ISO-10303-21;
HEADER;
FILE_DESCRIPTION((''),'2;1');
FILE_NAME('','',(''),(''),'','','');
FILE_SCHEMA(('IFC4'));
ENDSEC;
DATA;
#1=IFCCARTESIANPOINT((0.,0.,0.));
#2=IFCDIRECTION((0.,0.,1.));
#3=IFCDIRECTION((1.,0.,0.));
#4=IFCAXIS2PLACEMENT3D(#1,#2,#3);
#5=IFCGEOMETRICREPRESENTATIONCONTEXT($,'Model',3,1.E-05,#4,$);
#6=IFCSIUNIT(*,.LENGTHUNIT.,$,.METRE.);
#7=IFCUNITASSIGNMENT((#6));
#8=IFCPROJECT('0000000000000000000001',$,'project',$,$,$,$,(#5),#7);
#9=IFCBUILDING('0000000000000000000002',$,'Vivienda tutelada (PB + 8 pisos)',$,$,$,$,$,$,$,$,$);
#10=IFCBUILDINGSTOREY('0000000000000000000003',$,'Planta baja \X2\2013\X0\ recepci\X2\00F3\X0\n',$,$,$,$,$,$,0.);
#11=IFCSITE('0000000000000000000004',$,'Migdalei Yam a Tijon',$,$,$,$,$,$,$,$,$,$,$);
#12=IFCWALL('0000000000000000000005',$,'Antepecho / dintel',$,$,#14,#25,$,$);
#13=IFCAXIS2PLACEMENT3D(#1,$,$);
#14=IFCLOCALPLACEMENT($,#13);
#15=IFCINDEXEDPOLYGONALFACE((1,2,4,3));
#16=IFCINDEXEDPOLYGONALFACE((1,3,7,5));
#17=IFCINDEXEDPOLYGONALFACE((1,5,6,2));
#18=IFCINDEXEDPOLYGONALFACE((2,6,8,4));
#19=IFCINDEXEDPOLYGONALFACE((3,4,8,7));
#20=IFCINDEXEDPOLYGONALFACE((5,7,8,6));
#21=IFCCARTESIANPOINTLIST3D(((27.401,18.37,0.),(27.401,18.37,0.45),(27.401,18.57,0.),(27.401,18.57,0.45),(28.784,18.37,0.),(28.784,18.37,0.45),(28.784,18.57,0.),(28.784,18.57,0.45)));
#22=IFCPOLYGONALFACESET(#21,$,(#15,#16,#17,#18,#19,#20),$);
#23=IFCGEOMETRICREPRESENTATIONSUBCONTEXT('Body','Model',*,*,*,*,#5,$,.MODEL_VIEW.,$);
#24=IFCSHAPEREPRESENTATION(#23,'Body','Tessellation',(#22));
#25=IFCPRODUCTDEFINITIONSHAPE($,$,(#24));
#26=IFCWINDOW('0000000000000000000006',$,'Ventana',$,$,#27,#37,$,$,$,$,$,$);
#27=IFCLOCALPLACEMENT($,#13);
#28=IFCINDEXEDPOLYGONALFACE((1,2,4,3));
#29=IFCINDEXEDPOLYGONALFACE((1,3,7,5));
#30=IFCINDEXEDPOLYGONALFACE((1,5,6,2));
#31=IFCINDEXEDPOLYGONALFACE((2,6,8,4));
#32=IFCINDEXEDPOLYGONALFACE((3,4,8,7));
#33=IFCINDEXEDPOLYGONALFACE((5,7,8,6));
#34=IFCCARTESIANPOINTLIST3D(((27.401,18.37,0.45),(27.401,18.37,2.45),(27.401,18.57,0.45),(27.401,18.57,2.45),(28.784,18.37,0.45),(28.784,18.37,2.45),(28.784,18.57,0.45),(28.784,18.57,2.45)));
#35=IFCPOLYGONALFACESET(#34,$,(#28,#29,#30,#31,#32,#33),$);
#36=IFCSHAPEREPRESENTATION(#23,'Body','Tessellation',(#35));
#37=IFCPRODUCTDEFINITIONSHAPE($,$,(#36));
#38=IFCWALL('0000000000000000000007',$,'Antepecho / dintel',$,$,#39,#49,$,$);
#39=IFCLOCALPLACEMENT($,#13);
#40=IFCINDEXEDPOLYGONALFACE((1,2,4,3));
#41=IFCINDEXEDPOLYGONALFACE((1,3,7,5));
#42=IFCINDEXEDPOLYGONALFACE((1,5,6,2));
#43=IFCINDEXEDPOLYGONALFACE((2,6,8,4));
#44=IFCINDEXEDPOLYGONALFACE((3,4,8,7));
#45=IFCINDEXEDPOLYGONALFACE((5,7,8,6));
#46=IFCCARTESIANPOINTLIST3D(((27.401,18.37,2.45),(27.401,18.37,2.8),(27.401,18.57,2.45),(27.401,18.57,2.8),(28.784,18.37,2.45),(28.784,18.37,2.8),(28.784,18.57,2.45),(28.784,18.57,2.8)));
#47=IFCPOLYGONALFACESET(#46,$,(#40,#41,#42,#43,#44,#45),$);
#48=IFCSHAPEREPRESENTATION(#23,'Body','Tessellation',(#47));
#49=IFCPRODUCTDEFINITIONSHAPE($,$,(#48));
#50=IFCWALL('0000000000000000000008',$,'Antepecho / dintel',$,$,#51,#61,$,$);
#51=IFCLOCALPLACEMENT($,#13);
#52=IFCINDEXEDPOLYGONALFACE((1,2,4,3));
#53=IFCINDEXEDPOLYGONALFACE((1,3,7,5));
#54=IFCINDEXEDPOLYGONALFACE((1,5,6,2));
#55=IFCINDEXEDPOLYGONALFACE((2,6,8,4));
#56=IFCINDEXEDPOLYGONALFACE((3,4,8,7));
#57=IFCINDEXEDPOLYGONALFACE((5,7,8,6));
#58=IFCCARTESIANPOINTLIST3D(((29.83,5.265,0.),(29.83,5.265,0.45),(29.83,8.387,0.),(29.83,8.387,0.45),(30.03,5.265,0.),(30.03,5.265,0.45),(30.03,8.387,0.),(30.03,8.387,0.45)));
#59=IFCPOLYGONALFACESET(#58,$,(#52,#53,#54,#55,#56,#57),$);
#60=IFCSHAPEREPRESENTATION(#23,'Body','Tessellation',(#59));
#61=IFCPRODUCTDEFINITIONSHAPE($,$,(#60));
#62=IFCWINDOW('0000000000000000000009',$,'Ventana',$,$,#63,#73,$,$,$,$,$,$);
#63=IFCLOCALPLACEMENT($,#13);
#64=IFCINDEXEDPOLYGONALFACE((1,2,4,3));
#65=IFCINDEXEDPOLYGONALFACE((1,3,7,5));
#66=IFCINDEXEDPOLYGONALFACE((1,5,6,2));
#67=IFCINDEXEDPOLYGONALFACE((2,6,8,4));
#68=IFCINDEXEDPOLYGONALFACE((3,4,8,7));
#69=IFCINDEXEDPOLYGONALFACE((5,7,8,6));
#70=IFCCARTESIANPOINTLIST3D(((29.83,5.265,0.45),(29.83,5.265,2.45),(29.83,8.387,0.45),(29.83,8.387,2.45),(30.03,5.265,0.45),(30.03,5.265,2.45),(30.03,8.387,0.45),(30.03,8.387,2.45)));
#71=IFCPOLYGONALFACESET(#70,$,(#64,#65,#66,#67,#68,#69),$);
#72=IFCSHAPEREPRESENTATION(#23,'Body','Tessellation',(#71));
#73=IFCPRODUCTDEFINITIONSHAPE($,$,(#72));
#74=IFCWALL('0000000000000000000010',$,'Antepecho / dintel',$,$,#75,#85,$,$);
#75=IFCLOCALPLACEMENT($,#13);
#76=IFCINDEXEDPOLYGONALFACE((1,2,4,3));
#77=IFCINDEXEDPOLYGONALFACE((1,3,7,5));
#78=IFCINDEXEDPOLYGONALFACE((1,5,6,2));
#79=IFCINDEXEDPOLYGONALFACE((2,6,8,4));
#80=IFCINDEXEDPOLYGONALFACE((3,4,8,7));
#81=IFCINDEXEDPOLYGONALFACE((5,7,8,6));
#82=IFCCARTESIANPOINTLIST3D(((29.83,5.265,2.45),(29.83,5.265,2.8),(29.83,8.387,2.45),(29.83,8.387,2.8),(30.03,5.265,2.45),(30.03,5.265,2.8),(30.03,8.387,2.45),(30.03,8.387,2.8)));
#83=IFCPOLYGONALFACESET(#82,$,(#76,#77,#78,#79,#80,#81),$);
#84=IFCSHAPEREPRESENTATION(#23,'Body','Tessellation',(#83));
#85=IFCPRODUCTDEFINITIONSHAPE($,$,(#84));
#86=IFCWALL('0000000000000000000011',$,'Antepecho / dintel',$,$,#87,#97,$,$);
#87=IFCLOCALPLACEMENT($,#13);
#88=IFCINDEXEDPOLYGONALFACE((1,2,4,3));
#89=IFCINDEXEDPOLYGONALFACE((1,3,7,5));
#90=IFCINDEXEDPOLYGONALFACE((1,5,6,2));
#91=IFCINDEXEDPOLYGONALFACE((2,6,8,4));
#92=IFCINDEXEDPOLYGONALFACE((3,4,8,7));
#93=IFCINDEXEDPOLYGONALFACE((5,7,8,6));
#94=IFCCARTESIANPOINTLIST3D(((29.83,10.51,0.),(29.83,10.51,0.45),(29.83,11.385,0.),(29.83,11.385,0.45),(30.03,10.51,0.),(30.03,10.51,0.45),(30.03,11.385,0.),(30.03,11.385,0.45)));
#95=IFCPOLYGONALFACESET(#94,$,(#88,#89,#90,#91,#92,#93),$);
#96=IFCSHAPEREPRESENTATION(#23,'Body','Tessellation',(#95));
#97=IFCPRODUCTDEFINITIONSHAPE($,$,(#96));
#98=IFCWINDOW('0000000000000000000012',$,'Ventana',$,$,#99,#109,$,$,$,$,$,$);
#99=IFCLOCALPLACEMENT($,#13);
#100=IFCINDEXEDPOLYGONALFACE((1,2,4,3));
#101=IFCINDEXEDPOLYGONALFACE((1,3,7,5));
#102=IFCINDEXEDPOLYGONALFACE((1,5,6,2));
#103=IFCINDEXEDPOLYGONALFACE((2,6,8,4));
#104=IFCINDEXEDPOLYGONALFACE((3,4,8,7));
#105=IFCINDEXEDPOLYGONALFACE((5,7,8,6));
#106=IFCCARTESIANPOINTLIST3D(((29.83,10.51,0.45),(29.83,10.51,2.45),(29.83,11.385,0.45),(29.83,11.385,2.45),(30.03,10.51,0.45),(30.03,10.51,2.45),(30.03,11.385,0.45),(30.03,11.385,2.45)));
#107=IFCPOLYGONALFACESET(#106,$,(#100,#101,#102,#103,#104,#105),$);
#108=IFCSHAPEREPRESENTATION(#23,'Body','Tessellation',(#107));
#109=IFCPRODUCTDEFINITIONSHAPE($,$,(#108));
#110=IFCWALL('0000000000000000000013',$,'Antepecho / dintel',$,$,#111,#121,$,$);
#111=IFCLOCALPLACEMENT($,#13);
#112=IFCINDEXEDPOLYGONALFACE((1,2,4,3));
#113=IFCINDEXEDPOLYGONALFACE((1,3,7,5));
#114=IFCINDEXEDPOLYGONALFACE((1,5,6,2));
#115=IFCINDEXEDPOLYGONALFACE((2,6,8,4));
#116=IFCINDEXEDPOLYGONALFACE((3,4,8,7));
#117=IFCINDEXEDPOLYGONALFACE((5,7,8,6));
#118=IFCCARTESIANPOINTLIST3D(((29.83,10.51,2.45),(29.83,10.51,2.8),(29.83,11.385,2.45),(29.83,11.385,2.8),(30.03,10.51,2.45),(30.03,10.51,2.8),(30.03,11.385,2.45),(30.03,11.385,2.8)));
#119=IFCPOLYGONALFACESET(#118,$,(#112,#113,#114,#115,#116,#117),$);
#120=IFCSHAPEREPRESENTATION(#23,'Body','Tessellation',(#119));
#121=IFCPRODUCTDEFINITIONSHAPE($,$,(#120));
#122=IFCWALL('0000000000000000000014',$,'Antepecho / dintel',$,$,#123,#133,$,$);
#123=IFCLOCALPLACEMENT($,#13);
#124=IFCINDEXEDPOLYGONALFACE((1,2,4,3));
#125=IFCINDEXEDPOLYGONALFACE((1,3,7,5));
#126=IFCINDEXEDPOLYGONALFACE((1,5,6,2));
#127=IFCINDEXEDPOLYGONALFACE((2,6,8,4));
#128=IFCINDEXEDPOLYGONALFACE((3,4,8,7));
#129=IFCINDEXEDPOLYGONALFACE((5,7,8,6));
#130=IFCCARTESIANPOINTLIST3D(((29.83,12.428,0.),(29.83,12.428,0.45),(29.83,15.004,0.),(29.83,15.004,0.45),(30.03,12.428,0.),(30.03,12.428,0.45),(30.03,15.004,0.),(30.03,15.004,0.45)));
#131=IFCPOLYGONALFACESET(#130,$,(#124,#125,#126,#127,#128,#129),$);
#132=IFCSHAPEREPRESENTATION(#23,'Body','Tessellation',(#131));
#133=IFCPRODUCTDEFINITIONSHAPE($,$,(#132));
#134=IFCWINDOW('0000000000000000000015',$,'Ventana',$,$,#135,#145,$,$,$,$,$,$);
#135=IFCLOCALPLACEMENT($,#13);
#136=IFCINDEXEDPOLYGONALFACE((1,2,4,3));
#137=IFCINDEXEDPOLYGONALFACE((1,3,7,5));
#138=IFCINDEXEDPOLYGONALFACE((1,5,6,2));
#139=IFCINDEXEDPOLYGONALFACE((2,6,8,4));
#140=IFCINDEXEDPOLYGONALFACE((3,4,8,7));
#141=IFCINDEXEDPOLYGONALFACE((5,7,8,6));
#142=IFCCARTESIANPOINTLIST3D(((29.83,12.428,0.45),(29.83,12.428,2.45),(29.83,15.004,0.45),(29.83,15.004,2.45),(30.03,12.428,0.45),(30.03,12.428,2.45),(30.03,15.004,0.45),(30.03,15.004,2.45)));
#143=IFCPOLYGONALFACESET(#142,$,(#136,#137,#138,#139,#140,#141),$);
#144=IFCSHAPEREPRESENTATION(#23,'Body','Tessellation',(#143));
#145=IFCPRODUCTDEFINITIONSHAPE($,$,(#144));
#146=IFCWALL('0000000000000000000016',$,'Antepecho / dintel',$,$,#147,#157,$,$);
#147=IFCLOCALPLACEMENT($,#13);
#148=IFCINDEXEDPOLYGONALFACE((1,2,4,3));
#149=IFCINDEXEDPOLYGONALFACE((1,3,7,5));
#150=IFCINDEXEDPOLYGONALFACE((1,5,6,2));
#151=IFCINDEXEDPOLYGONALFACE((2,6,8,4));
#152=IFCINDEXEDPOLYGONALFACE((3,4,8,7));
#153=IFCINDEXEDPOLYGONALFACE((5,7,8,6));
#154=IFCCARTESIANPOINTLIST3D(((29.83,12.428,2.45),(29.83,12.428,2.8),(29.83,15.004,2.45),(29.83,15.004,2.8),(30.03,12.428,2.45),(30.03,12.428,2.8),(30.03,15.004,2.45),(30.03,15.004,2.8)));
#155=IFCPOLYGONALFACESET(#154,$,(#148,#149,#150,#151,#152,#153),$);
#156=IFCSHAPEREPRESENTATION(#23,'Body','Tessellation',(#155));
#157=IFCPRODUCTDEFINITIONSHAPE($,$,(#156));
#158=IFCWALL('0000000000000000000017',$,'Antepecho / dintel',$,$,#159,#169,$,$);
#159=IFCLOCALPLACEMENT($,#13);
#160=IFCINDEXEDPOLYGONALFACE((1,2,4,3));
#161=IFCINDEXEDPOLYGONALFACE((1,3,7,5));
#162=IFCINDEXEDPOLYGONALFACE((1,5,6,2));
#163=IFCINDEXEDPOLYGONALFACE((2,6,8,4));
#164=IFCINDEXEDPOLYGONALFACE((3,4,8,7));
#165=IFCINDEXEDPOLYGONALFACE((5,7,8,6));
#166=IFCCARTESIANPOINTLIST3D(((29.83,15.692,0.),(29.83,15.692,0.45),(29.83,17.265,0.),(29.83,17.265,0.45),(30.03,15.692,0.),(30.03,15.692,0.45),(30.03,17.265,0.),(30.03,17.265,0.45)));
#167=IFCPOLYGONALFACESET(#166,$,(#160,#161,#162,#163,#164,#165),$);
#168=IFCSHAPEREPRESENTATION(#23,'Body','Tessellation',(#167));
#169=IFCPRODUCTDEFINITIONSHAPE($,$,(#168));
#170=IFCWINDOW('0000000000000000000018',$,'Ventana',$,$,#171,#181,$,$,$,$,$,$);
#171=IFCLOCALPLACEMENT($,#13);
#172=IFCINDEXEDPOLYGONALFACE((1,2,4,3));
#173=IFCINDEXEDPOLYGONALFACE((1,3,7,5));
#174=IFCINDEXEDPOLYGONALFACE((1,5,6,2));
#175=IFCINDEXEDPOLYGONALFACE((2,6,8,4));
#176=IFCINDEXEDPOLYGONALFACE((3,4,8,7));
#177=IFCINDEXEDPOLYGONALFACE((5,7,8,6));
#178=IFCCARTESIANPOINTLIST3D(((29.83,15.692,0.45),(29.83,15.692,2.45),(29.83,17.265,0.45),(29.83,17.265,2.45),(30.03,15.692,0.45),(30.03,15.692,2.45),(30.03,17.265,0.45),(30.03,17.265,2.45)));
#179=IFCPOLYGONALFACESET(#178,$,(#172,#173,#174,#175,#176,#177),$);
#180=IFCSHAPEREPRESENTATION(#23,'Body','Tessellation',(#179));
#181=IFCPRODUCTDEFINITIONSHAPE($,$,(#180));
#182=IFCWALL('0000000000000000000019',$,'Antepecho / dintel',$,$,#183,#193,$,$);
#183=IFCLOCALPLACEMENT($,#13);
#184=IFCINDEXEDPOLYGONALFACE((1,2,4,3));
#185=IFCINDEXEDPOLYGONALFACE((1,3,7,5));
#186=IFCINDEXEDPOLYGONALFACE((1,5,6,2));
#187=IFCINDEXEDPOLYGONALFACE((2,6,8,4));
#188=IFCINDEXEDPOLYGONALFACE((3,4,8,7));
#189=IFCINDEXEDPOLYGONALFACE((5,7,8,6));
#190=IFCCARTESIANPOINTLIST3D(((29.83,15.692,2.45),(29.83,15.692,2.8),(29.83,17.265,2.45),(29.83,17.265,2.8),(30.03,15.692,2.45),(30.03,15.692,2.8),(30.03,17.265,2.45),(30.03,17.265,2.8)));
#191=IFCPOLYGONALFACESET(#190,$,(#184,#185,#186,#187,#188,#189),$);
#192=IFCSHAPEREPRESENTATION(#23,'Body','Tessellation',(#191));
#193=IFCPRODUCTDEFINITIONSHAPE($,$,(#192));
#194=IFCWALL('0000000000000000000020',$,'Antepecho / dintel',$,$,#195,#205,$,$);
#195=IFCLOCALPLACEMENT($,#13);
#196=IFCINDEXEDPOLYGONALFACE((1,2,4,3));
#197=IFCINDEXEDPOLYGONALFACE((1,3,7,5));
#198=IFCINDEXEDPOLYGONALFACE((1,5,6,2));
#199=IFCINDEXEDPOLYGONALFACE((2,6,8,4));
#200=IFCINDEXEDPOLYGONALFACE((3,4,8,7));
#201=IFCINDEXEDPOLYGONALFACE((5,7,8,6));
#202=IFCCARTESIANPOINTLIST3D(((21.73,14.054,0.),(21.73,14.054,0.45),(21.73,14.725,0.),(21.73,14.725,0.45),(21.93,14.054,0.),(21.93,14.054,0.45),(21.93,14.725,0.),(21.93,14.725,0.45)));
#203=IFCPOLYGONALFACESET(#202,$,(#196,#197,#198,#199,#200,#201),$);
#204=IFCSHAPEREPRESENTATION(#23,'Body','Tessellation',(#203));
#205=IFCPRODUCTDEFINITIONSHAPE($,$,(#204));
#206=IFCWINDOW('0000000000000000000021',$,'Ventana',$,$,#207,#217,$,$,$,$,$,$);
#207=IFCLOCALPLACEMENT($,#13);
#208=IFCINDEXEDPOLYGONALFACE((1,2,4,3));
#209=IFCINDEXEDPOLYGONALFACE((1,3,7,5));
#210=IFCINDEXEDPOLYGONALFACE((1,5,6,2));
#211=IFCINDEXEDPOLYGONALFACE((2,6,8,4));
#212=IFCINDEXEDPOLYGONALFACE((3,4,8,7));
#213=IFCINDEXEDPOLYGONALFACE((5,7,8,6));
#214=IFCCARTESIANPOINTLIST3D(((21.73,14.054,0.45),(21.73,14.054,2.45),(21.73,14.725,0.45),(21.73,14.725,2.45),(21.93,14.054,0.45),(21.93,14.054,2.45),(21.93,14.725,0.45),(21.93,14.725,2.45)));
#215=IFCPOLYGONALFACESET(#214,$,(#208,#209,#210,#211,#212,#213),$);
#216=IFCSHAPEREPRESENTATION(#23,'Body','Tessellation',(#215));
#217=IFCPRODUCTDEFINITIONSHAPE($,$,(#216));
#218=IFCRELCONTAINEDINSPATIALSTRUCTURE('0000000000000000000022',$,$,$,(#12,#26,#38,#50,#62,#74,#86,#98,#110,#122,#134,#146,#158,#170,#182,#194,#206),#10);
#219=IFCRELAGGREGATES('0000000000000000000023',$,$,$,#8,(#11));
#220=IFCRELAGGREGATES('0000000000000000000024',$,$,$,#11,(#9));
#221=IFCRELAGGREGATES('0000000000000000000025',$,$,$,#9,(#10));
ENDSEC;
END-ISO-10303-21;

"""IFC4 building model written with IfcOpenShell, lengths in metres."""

from ifc_helpers import new_model, si_unit, frame, origin_with_axes, context, subcontext, project, spatial, line, indexed_curve, outline, extrude, element, save


model = new_model("IFC4")

# Units and contexts
model_context = context("Model", 3, precision=1e-05, world=origin_with_axes())
body_context = subcontext(model_context, "Body", "Model", "MODEL_VIEW")
ifc_project = project(units=[si_unit("LENGTHUNIT", "METRE")], contexts=[model_context])

# Site, building, storey
site = spatial("IfcSite", under=ifc_project, Name="Migdalei Yam a Tijon")
building = spatial("IfcBuilding", under=site, Name="Vivienda tutelada (PB + 8 pisos)")
storey = spatial("IfcBuildingStorey", under=building, Name="Planta baja – recepción", Elevation=0.0)

# Wall
element("IfcWall", 1, inside=storey, Name="Antepecho / dintel", context=body_context, shape_type="SweptSolid", body=[
    extrude(outline(indexed_curve([(0.0, 0.0), (1.383, 0.0), (1.383, 0.2), (0.0, 0.2)], segments=[line(1, 2, 3, 4, 1)])), frame((27.401, 18.37, 0.0), z_axis=(0.0, 0.0, 1.0), x_axis=(1.0, 0.0, 0.0)), (0.0, 0.0, 1.0), 0.45),
])

# Window
element("IfcWindow", 2, inside=storey, Name="Ventana", context=body_context, shape_type="SweptSolid", body=[
    extrude(outline(indexed_curve([(0.0, 0.0), (1.383, 0.0), (1.383, 0.2), (0.0, 0.2)], segments=[line(1, 2, 3, 4, 1)])), frame((27.401, 18.37, 0.45), z_axis=(0.0, 0.0, 1.0), x_axis=(1.0, 0.0, 0.0)), (0.0, 0.0, 1.0), 2.0),
])

# Walls
element("IfcWall", 3, inside=storey, Name="Antepecho / dintel", context=body_context, shape_type="SweptSolid", body=[
    extrude(outline(indexed_curve([(0.0, 0.0), (1.383, 0.0), (1.383, 0.2), (0.0, 0.2)], segments=[line(1, 2, 3, 4, 1)])), frame((27.401, 18.37, 2.45), z_axis=(0.0, 0.0, 1.0), x_axis=(1.0, 0.0, 0.0)), (0.0, 0.0, 1.0), 0.35),
])
element("IfcWall", 4, inside=storey, Name="Antepecho / dintel", context=body_context, shape_type="SweptSolid", body=[
    extrude(outline(indexed_curve([(0.0, 0.0), (0.2, 0.0), (0.2, 3.122), (0.0, 3.122)], segments=[line(1, 2, 3, 4, 1)])), frame((29.83, 5.265, 0.0), z_axis=(0.0, 0.0, 1.0), x_axis=(1.0, 0.0, 0.0)), (0.0, 0.0, 1.0), 0.45),
])

# Window
element("IfcWindow", 5, inside=storey, Name="Ventana", context=body_context, shape_type="SweptSolid", body=[
    extrude(outline(indexed_curve([(0.0, 0.0), (0.2, 0.0), (0.2, 3.122), (0.0, 3.122)], segments=[line(1, 2, 3, 4, 1)])), frame((29.83, 5.265, 0.45), z_axis=(0.0, 0.0, 1.0), x_axis=(1.0, 0.0, 0.0)), (0.0, 0.0, 1.0), 2.0),
])

# Walls
element("IfcWall", 6, inside=storey, Name="Antepecho / dintel", context=body_context, shape_type="SweptSolid", body=[
    extrude(outline(indexed_curve([(0.0, 0.0), (0.2, 0.0), (0.2, 3.122), (0.0, 3.122)], segments=[line(1, 2, 3, 4, 1)])), frame((29.83, 5.265, 2.45), z_axis=(0.0, 0.0, 1.0), x_axis=(1.0, 0.0, 0.0)), (0.0, 0.0, 1.0), 0.35),
])
element("IfcWall", 7, inside=storey, Name="Antepecho / dintel", context=body_context, shape_type="SweptSolid", body=[
    extrude(outline(indexed_curve([(0.0, 0.0), (0.2, 0.0), (0.2, 0.875), (0.0, 0.875)], segments=[line(1, 2, 3, 4, 1)])), frame((29.83, 10.51, 0.0), z_axis=(0.0, 0.0, 1.0), x_axis=(1.0, 0.0, 0.0)), (0.0, 0.0, 1.0), 0.45),
])

# Window
element("IfcWindow", 8, inside=storey, Name="Ventana", context=body_context, shape_type="SweptSolid", body=[
    extrude(outline(indexed_curve([(0.0, 0.0), (0.2, 0.0), (0.2, 0.875), (0.0, 0.875)], segments=[line(1, 2, 3, 4, 1)])), frame((29.83, 10.51, 0.45), z_axis=(0.0, 0.0, 1.0), x_axis=(1.0, 0.0, 0.0)), (0.0, 0.0, 1.0), 2.0),
])

# Walls
element("IfcWall", 9, inside=storey, Name="Antepecho / dintel", context=body_context, shape_type="SweptSolid", body=[
    extrude(outline(indexed_curve([(0.0, 0.0), (0.2, 0.0), (0.2, 0.875), (0.0, 0.875)], segments=[line(1, 2, 3, 4, 1)])), frame((29.83, 10.51, 2.45), z_axis=(0.0, 0.0, 1.0), x_axis=(1.0, 0.0, 0.0)), (0.0, 0.0, 1.0), 0.35),
])
element("IfcWall", 10, inside=storey, Name="Antepecho / dintel", context=body_context, shape_type="SweptSolid", body=[
    extrude(outline(indexed_curve([(0.0, 0.0), (0.2, 0.0), (0.2, 2.576), (0.0, 2.576)], segments=[line(1, 2, 3, 4, 1)])), frame((29.83, 12.428, 0.0), z_axis=(0.0, 0.0, 1.0), x_axis=(1.0, 0.0, 0.0)), (0.0, 0.0, 1.0), 0.45),
])

# Window
element("IfcWindow", 11, inside=storey, Name="Ventana", context=body_context, shape_type="SweptSolid", body=[
    extrude(outline(indexed_curve([(0.0, 0.0), (0.2, 0.0), (0.2, 2.576), (0.0, 2.576)], segments=[line(1, 2, 3, 4, 1)])), frame((29.83, 12.428, 0.45), z_axis=(0.0, 0.0, 1.0), x_axis=(1.0, 0.0, 0.0)), (0.0, 0.0, 1.0), 2.0),
])

# Walls
element("IfcWall", 12, inside=storey, Name="Antepecho / dintel", context=body_context, shape_type="SweptSolid", body=[
    extrude(outline(indexed_curve([(0.0, 0.0), (0.2, 0.0), (0.2, 2.576), (0.0, 2.576)], segments=[line(1, 2, 3, 4, 1)])), frame((29.83, 12.428, 2.45), z_axis=(0.0, 0.0, 1.0), x_axis=(1.0, 0.0, 0.0)), (0.0, 0.0, 1.0), 0.35),
])
element("IfcWall", 13, inside=storey, Name="Antepecho / dintel", context=body_context, shape_type="SweptSolid", body=[
    extrude(outline(indexed_curve([(0.0, 0.0), (0.2, 0.0), (0.2, 1.573), (0.0, 1.573)], segments=[line(1, 2, 3, 4, 1)])), frame((29.83, 15.692, 0.0), z_axis=(0.0, 0.0, 1.0), x_axis=(1.0, 0.0, 0.0)), (0.0, 0.0, 1.0), 0.45),
])

# Window
element("IfcWindow", 14, inside=storey, Name="Ventana", context=body_context, shape_type="SweptSolid", body=[
    extrude(outline(indexed_curve([(0.0, 0.0), (0.2, 0.0), (0.2, 1.573), (0.0, 1.573)], segments=[line(1, 2, 3, 4, 1)])), frame((29.83, 15.692, 0.45), z_axis=(0.0, 0.0, 1.0), x_axis=(1.0, 0.0, 0.0)), (0.0, 0.0, 1.0), 2.0),
])

# Walls
element("IfcWall", 15, inside=storey, Name="Antepecho / dintel", context=body_context, shape_type="SweptSolid", body=[
    extrude(outline(indexed_curve([(0.0, 0.0), (0.2, 0.0), (0.2, 1.573), (0.0, 1.573)], segments=[line(1, 2, 3, 4, 1)])), frame((29.83, 15.692, 2.45), z_axis=(0.0, 0.0, 1.0), x_axis=(1.0, 0.0, 0.0)), (0.0, 0.0, 1.0), 0.35),
])
element("IfcWall", 16, inside=storey, Name="Antepecho / dintel", context=body_context, shape_type="SweptSolid", body=[
    extrude(outline(indexed_curve([(0.0, 0.0), (0.2, 0.0), (0.2, 0.671), (0.0, 0.671)], segments=[line(1, 2, 3, 4, 1)])), frame((21.73, 14.054, 0.0), z_axis=(0.0, 0.0, 1.0), x_axis=(1.0, 0.0, 0.0)), (0.0, 0.0, 1.0), 0.45),
])

# Window
element("IfcWindow", 17, inside=storey, Name="Ventana", context=body_context, shape_type="SweptSolid", body=[
    extrude(outline(indexed_curve([(0.0, 0.0), (0.2, 0.0), (0.2, 0.671), (0.0, 0.671)], segments=[line(1, 2, 3, 4, 1)])), frame((21.73, 14.054, 0.45), z_axis=(0.0, 0.0, 1.0), x_axis=(1.0, 0.0, 0.0)), (0.0, 0.0, 1.0), 2.0),
])

save(model, "model.ifc")
